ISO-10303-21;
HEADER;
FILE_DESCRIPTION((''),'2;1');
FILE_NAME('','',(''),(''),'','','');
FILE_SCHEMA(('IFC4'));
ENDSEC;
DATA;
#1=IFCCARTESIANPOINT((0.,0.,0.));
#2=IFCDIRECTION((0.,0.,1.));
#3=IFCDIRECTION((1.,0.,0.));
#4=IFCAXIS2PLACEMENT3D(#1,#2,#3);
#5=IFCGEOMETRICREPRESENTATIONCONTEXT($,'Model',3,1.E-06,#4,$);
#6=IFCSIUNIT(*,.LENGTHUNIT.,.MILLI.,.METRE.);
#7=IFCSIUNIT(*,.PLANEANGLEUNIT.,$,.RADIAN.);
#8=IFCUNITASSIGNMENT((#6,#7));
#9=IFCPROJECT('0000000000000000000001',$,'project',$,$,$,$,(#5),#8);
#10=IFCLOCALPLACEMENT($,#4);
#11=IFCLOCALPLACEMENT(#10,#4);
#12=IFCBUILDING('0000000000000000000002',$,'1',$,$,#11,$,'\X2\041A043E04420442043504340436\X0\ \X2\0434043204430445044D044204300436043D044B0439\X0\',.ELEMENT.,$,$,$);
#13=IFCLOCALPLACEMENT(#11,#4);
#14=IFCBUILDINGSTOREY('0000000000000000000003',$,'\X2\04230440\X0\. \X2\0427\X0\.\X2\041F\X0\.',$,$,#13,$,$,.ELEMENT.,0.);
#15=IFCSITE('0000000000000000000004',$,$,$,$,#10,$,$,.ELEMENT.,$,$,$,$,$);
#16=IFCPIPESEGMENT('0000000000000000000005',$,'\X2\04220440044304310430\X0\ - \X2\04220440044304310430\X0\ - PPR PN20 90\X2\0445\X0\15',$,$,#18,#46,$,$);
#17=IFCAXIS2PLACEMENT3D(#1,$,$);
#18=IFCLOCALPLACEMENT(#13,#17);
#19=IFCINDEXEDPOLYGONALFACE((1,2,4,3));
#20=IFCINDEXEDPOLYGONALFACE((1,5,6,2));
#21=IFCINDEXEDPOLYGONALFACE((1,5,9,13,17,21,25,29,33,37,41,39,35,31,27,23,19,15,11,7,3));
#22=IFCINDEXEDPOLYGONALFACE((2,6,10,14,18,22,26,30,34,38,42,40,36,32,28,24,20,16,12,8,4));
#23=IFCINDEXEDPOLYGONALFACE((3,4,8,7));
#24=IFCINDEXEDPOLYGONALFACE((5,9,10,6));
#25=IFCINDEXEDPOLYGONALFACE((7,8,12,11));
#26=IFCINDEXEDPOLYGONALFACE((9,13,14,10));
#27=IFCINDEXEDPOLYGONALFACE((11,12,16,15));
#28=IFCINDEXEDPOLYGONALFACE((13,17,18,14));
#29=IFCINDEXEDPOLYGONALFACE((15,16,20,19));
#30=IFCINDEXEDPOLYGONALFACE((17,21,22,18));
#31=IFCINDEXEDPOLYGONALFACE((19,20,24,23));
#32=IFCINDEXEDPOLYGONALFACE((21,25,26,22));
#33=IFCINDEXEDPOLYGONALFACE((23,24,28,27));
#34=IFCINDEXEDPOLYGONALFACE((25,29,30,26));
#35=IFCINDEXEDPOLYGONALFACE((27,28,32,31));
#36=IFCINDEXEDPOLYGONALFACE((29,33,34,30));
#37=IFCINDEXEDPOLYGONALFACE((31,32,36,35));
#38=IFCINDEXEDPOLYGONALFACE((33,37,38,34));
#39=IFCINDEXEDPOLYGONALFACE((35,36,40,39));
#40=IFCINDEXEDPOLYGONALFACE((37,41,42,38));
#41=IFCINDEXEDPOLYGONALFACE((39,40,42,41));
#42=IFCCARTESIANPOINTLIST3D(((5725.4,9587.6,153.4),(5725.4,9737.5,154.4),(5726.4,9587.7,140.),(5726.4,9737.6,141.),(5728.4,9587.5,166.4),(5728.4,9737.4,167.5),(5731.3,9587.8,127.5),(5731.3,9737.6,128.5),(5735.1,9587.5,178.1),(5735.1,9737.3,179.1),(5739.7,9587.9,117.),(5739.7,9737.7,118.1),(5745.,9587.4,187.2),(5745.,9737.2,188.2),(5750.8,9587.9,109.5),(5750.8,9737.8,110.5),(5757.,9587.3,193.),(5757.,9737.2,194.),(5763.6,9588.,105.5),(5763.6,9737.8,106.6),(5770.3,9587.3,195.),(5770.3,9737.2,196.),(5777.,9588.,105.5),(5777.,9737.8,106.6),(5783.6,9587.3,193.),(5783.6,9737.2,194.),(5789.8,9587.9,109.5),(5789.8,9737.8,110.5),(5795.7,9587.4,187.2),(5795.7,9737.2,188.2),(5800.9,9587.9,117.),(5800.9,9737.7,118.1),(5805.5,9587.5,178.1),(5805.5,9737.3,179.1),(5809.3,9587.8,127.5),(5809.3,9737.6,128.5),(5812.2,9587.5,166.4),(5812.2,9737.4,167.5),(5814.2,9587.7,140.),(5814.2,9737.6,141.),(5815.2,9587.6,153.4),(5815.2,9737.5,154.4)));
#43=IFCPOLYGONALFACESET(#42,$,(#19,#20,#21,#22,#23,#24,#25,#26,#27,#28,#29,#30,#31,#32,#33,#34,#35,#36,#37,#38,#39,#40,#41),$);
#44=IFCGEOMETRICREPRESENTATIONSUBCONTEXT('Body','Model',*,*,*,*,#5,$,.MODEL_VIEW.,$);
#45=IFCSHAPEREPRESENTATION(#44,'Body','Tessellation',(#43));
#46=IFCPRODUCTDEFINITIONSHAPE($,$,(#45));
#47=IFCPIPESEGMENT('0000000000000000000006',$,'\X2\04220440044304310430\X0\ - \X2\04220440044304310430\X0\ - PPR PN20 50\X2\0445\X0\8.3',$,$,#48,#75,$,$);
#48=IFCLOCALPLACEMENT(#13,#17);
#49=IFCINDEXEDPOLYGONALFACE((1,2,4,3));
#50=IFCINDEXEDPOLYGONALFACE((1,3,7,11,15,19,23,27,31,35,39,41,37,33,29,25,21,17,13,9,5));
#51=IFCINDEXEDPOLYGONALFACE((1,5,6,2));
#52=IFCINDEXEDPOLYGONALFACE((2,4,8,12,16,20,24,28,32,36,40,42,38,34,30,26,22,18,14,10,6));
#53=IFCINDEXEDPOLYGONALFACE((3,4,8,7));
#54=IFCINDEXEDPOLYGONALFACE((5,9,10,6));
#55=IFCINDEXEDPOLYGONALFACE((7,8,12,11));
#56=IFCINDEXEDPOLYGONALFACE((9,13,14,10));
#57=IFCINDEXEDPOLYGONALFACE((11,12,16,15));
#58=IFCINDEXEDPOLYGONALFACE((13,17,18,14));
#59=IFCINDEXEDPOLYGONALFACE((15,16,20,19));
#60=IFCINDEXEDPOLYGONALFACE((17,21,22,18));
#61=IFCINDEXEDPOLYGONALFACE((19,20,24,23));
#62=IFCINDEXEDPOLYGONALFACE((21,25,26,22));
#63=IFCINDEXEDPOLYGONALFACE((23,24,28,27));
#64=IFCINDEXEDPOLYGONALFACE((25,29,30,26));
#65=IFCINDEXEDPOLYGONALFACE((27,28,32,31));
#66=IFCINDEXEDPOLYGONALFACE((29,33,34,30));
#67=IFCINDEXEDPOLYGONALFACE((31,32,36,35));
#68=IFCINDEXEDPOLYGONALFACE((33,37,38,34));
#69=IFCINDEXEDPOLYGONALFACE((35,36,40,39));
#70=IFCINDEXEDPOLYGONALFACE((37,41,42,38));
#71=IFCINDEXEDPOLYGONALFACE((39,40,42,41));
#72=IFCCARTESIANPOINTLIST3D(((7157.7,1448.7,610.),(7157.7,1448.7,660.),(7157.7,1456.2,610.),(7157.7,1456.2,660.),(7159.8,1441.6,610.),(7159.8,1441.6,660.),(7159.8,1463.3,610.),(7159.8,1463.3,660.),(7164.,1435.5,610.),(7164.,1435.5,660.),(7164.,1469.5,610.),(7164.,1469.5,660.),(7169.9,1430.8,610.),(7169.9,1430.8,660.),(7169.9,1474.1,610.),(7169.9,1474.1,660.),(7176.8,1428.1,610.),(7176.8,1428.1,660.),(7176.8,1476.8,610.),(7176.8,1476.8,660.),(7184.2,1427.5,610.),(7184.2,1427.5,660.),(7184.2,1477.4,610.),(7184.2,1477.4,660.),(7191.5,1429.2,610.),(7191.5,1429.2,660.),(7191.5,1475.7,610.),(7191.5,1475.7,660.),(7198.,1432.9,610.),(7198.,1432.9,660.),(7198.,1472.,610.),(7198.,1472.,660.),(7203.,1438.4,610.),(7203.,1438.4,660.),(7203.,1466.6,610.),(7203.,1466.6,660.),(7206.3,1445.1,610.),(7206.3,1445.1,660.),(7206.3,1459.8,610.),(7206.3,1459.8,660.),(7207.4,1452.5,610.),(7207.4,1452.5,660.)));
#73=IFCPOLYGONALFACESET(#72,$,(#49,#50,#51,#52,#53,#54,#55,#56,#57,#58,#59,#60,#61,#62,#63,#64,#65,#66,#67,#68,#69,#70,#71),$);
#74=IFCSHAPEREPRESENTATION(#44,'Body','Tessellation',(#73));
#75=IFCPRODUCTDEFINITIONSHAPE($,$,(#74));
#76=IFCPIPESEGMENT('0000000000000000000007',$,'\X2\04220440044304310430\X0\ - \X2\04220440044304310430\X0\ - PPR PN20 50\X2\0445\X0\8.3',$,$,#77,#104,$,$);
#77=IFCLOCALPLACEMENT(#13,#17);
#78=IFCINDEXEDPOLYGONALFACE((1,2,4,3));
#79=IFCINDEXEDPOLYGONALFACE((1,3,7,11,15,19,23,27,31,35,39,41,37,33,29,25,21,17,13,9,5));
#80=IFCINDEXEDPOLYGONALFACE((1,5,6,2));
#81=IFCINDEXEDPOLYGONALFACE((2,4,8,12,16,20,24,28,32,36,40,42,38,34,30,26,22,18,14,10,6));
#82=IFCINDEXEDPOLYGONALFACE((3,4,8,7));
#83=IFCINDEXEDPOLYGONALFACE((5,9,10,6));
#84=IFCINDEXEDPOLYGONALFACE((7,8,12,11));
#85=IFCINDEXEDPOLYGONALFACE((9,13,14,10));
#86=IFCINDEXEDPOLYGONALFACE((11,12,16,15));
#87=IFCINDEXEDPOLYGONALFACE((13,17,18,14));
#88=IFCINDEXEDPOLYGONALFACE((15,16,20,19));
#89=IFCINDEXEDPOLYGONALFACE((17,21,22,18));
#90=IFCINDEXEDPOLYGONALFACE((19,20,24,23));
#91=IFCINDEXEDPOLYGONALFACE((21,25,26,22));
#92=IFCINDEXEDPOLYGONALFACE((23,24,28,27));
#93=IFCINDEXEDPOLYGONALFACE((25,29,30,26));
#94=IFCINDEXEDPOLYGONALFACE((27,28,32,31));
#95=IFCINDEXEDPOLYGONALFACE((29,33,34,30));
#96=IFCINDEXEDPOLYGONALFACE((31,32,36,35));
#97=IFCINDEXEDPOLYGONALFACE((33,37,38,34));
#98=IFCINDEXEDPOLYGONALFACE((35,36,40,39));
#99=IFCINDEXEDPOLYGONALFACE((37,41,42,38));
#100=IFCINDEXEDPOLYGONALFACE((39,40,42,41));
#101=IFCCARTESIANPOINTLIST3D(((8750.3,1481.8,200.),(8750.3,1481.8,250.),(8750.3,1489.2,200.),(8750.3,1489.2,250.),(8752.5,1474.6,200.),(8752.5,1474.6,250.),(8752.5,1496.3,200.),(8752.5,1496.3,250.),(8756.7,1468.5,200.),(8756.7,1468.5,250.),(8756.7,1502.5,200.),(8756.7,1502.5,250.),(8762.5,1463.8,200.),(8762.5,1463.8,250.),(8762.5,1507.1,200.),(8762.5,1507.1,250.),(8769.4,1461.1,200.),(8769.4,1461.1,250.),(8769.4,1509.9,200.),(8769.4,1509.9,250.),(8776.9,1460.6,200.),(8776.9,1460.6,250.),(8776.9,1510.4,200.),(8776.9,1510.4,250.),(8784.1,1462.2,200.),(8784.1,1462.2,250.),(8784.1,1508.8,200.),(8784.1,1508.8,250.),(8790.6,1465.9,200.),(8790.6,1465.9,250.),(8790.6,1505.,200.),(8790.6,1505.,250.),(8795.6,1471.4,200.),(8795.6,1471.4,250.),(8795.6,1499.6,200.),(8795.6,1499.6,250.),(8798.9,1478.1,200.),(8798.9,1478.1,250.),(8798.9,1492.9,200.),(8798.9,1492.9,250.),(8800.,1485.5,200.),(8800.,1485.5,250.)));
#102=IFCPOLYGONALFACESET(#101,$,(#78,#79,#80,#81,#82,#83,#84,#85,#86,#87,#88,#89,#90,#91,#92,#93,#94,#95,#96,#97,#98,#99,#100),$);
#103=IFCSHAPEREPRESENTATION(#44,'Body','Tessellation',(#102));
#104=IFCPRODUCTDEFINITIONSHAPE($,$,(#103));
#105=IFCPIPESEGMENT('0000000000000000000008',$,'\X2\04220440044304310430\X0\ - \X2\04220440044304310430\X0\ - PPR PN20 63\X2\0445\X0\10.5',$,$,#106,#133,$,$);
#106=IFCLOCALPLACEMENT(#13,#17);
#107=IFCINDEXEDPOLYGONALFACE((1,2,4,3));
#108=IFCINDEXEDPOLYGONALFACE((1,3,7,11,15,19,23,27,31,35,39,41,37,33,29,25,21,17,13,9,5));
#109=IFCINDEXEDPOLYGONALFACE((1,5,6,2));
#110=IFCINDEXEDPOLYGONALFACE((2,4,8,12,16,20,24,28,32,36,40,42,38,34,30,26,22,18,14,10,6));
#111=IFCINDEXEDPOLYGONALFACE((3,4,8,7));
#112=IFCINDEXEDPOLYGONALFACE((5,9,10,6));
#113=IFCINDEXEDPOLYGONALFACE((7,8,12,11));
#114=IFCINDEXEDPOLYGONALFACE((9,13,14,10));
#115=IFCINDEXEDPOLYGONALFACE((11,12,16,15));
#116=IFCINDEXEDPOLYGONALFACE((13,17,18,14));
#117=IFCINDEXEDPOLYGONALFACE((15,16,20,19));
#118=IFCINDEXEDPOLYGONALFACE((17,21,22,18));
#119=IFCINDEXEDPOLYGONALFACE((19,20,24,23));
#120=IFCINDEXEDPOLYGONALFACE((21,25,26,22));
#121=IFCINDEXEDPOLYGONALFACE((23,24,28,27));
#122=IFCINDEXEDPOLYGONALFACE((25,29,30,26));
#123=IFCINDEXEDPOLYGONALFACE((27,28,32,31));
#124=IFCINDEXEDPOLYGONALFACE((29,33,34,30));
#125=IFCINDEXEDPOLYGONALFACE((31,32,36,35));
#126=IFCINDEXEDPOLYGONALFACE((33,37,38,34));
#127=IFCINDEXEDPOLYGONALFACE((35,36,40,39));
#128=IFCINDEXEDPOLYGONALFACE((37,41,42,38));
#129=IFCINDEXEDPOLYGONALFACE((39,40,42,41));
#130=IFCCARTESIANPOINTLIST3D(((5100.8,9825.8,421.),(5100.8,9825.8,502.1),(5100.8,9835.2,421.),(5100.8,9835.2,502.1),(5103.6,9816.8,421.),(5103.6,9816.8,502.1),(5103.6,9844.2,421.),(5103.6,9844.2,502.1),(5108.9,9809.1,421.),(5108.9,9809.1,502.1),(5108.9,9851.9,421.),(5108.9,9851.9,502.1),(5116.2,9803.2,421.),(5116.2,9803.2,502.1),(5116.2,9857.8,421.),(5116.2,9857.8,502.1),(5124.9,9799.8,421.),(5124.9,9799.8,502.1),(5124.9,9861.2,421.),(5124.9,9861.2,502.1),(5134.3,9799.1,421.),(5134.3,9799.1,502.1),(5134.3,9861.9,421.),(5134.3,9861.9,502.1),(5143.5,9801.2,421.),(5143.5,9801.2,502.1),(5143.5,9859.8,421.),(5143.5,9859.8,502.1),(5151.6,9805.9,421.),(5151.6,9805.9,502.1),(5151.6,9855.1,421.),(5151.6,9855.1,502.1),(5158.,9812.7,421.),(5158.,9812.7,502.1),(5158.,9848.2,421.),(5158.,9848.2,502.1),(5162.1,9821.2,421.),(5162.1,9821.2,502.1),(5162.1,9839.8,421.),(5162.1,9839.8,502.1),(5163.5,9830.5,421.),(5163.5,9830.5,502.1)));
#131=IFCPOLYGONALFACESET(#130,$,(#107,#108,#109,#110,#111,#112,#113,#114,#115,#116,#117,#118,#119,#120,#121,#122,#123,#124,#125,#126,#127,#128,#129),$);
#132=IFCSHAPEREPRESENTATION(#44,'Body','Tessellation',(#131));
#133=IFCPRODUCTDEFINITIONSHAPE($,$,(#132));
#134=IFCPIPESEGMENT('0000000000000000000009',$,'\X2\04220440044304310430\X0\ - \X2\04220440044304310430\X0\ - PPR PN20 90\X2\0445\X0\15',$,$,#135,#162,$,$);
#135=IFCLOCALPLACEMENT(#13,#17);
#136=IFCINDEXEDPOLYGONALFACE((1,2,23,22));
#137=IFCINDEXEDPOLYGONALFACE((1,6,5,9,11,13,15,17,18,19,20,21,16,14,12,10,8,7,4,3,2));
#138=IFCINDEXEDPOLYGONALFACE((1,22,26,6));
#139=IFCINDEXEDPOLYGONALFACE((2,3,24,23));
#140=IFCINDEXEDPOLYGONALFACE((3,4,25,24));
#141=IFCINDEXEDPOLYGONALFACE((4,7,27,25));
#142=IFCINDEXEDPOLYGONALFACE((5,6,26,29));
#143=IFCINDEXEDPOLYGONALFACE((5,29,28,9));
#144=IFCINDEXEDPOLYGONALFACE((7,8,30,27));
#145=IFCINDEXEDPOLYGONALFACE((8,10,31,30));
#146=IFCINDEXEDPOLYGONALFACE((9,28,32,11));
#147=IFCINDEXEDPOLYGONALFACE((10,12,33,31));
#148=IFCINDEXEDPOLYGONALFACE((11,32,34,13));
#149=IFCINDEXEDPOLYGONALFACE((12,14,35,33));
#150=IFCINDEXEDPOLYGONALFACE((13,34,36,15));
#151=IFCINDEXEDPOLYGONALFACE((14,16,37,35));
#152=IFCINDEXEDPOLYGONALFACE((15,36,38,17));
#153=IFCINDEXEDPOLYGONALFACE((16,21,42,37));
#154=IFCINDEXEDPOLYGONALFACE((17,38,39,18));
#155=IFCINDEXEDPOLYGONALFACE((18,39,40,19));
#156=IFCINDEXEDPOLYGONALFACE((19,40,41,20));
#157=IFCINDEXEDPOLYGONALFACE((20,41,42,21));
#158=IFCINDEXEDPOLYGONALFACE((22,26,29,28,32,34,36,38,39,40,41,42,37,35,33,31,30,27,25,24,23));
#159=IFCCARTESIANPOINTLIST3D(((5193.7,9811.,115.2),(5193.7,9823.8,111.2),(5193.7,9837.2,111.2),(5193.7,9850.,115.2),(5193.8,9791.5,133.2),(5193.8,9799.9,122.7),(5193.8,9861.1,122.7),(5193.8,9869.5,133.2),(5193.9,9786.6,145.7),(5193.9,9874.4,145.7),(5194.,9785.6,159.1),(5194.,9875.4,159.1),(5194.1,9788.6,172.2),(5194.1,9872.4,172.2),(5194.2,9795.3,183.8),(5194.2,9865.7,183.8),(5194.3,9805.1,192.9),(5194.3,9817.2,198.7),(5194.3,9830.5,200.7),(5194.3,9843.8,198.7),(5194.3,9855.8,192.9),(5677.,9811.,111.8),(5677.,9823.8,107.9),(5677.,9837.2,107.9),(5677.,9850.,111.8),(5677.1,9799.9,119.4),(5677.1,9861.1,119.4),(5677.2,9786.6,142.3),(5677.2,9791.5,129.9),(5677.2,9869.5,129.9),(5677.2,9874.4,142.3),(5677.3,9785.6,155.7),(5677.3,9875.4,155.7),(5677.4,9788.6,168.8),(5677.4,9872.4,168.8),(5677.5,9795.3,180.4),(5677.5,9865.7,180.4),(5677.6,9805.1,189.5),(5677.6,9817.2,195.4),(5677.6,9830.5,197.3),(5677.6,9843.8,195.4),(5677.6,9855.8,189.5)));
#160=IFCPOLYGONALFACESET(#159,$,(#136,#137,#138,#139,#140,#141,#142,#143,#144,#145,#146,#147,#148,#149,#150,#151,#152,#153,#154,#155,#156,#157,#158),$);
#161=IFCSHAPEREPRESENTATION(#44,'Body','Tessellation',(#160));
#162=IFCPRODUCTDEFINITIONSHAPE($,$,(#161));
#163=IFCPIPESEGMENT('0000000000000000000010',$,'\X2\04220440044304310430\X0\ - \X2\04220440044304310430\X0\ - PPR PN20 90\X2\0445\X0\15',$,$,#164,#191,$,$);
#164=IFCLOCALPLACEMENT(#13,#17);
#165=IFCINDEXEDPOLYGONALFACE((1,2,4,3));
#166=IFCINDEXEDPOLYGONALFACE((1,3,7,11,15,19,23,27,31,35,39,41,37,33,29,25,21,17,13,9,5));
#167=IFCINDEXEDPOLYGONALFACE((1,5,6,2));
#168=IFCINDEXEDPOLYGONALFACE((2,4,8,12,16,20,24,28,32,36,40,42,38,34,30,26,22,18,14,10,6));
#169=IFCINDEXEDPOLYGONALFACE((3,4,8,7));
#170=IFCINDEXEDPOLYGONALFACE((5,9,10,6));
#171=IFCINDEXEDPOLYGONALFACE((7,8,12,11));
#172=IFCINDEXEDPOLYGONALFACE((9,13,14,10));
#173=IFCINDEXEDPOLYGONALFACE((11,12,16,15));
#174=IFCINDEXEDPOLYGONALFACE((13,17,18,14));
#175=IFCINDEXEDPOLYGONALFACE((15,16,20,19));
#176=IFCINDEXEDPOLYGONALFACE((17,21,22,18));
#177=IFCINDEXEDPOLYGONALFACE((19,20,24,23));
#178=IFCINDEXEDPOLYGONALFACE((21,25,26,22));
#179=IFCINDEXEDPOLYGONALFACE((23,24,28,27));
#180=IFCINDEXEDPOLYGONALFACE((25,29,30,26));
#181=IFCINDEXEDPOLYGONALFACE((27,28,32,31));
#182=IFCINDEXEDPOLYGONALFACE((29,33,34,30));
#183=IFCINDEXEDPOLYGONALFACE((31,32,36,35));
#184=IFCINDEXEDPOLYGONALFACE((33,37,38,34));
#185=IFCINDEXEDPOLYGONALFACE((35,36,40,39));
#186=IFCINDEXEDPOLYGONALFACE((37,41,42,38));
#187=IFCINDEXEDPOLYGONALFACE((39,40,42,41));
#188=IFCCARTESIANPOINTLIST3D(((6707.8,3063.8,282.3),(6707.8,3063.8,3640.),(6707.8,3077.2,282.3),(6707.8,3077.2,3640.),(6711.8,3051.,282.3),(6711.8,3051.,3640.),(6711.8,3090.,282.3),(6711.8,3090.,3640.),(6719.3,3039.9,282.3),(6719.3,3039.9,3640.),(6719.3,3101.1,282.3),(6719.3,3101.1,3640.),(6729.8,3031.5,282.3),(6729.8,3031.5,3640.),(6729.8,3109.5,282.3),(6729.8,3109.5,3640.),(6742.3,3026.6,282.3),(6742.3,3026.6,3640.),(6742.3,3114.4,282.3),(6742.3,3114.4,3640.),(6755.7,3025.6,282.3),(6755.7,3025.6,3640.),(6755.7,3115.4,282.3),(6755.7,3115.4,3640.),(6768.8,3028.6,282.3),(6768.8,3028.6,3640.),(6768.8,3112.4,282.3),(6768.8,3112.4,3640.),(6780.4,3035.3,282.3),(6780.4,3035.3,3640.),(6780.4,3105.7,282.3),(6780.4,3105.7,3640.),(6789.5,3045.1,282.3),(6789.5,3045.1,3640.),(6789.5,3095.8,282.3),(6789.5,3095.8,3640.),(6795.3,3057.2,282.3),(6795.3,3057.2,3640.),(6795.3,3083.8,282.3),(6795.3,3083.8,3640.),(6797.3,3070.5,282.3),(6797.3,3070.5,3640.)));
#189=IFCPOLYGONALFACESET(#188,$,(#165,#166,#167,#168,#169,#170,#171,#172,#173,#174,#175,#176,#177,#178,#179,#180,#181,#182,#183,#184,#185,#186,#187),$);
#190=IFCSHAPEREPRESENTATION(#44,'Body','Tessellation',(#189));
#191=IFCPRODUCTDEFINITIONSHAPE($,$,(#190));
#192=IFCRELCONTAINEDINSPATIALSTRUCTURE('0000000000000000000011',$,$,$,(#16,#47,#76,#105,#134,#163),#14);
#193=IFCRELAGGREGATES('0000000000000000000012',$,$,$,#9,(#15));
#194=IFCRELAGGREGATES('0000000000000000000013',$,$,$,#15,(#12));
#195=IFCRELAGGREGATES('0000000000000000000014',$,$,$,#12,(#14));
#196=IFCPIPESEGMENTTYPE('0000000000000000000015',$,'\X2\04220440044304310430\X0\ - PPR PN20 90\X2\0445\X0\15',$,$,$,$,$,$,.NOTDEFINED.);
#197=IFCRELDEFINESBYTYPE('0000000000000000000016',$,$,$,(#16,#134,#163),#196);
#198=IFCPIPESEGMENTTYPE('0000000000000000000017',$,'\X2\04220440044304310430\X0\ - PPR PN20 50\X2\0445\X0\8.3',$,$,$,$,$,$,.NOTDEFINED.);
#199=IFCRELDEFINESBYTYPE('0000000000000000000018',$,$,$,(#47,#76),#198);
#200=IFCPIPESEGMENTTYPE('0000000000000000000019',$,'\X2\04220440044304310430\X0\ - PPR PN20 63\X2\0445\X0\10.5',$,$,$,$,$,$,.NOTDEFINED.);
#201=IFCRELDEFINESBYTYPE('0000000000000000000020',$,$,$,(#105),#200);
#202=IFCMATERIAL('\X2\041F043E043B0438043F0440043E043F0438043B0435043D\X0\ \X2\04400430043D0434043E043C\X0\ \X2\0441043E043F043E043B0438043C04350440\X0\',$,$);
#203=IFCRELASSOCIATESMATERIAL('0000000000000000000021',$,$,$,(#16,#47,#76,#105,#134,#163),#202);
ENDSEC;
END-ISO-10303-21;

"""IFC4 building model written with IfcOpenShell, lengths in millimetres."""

from ifc_helpers import new_model, entity, si_unit, frame, origin_with_axes, place, context, subcontext, project, spatial, source, transform, mapped, material, type_object, element, save


model = new_model("IFC4")

# Units and contexts
model_context = context("Model", 3, precision=1e-06, world=origin_with_axes())
body_context = subcontext(model_context, "Body", "Model", "MODEL_VIEW")
ifc_project = project(units=[si_unit("LENGTHUNIT", "METRE", prefix="MILLI"), si_unit("PLANEANGLEUNIT", "RADIAN")], contexts=[model_context])

# Site, building, storey
site_placement = place(None, origin_with_axes())
site = spatial("IfcSite", under=ifc_project, at=site_placement, CompositionType="ELEMENT")
building_placement = place(site_placement, origin_with_axes())
building = spatial("IfcBuilding", under=site, at=building_placement, Name="1", LongName="Коттедж двухэтажный", CompositionType="ELEMENT")
storey_placement = place(building_placement, origin_with_axes())
storey = spatial("IfcBuildingStorey", under=building, at=storey_placement, Name="Ур. Ч.П.", CompositionType="ELEMENT", Elevation=0.0)

# Pipe segments
ifc_material = material(Name="Полипропилен рандом сополимер")
pipe_segment_type_1 = type_object("IfcPipeSegmentType", Name="Труба - PPR PN20 90х15", PredefinedType="NOTDEFINED")
shared_shape_1 = source(origin_with_axes(), body_context, "Body", "AdvancedSweptSolid", [
    entity("IfcSweptDiskSolid", entity("IfcIndexedPolyCurve", entity("IfcCartesianPointList3D", [[0.0, 0.0, 0.0], [149.8, 0.0, 1.0]]), [entity("IfcLineIndex", [1, 2])]), 45.0),
])
pipe_segment_1_placement = place(storey_placement, frame((5770.3, 9587.6, 150.0), z_axis=(0.0, 0.0, 1.0), x_axis=(0.0, 1.0, 0.0)))
element("IfcPipeSegment", 1, at=pipe_segment_1_placement, inside=storey, type_object=pipe_segment_type_1, material=ifc_material, Name="Труба - Труба - PPR PN20 90х15", context=body_context, shape_type="MappedRepresentation", body=[
    mapped(shared_shape_1, transform((0.0, 0.0, 0.0), x_axis=(1.0, 0.0, 0.0), y_axis=(0.0, 1.0, 0.0), z_axis=(0.0, 0.0, 1.0), scale=1.0)),
])
pipe_segment_type_2 = type_object("IfcPipeSegmentType", Name="Труба - PPR PN20 50х8.3", PredefinedType="NOTDEFINED")
shared_shape_2 = source(origin_with_axes(), body_context, "Body", "AdvancedSweptSolid", [
    entity("IfcSweptDiskSolid", entity("IfcIndexedPolyCurve", entity("IfcCartesianPointList3D", [[0.0, 0.0, 0.0], [0.0, 0.0, 50.0]]), [entity("IfcLineIndex", [1, 2])]), 25.0),
])
for number, where, z_axis, x_axis, name in (
    (2, (7182.4, 1452.5, 660.0), (0.0, 0.0, -1.0), (1.0, 0.0, 0.0), "Труба - Труба - PPR PN20 50х8.3"),
    (3, (8775.0, 1485.5, 250.0), (0.0, 0.0, -1.0), (1.0, 0.0, 0.0), "Труба - Труба - PPR PN20 50х8.3"),
):
    element("IfcPipeSegment", number, at=place(storey_placement, frame(where, z_axis=z_axis, x_axis=x_axis)), inside=storey, type_object=pipe_segment_type_2, material=ifc_material, Name=name, context=body_context, shape_type="MappedRepresentation", body=[
        mapped(shared_shape_2, transform((0.0, 0.0, 0.0), x_axis=(1.0, 0.0, 0.0), y_axis=(0.0, 1.0, 0.0), z_axis=(0.0, 0.0, 1.0), scale=1.0)),
    ])
pipe_segment_type_3 = type_object("IfcPipeSegmentType", Name="Труба - PPR PN20 63х10.5", PredefinedType="NOTDEFINED")
shared_shape_3 = source(origin_with_axes(), body_context, "Body", "AdvancedSweptSolid", [
    entity("IfcSweptDiskSolid", entity("IfcIndexedPolyCurve", entity("IfcCartesianPointList3D", [[0.0, 0.0, 0.0], [0.0, 0.0, 81.1]]), [entity("IfcLineIndex", [1, 2])]), 31.5),
])
pipe_segment_2_placement = place(storey_placement, frame((5132.0, 9830.5, 502.1), z_axis=(0.0, 0.0, -1.0), x_axis=(1.0, 0.0, 0.0)))
element("IfcPipeSegment", 4, at=pipe_segment_2_placement, inside=storey, type_object=pipe_segment_type_3, material=ifc_material, Name="Труба - Труба - PPR PN20 63х10.5", context=body_context, shape_type="MappedRepresentation", body=[
    mapped(shared_shape_3, transform((0.0, 0.0, 0.0), x_axis=(1.0, 0.0, 0.0), y_axis=(0.0, 1.0, 0.0), z_axis=(0.0, 0.0, 1.0), scale=1.0)),
])
shared_shape_4 = source(origin_with_axes(), body_context, "Body", "AdvancedSweptSolid", [
    entity("IfcSweptDiskSolid", entity("IfcIndexedPolyCurve", entity("IfcCartesianPointList3D", [[0.0, 0.0, 0.0], [483.3, 0.0, 3.4]]), [entity("IfcLineIndex", [1, 2])]), 45.0),
])
pipe_segment_3_placement = place(storey_placement, frame((5677.3, 9830.5, 152.4), z_axis=(0.0, 0.0, 1.0), x_axis=(-1.0, 0.0, 0.0)))
element("IfcPipeSegment", 5, at=pipe_segment_3_placement, inside=storey, type_object=pipe_segment_type_1, material=ifc_material, Name="Труба - Труба - PPR PN20 90х15", context=body_context, shape_type="MappedRepresentation", body=[
    mapped(shared_shape_4, transform((0.0, 0.0, 0.0), x_axis=(1.0, 0.0, 0.0), y_axis=(0.0, 1.0, 0.0), z_axis=(0.0, 0.0, 1.0), scale=1.0)),
])
shared_shape_5 = source(origin_with_axes(), body_context, "Body", "AdvancedSweptSolid", [
    entity("IfcSweptDiskSolid", entity("IfcIndexedPolyCurve", entity("IfcCartesianPointList3D", [[0.0, 0.0, 0.0], [0.0, 0.0, 3357.7]]), [entity("IfcLineIndex", [1, 2])]), 45.0),
])
pipe_segment_4_placement = place(storey_placement, frame((6752.3, 3070.5, 3640.0), z_axis=(0.0, 0.0, -1.0), x_axis=(1.0, 0.0, 0.0)))
element("IfcPipeSegment", 6, at=pipe_segment_4_placement, inside=storey, type_object=pipe_segment_type_1, material=ifc_material, Name="Труба - Труба - PPR PN20 90х15", context=body_context, shape_type="MappedRepresentation", body=[
    mapped(shared_shape_5, transform((0.0, 0.0, 0.0), x_axis=(1.0, 0.0, 0.0), y_axis=(0.0, 1.0, 0.0), z_axis=(0.0, 0.0, 1.0), scale=1.0)),
])

save(model, "model.ifc")
